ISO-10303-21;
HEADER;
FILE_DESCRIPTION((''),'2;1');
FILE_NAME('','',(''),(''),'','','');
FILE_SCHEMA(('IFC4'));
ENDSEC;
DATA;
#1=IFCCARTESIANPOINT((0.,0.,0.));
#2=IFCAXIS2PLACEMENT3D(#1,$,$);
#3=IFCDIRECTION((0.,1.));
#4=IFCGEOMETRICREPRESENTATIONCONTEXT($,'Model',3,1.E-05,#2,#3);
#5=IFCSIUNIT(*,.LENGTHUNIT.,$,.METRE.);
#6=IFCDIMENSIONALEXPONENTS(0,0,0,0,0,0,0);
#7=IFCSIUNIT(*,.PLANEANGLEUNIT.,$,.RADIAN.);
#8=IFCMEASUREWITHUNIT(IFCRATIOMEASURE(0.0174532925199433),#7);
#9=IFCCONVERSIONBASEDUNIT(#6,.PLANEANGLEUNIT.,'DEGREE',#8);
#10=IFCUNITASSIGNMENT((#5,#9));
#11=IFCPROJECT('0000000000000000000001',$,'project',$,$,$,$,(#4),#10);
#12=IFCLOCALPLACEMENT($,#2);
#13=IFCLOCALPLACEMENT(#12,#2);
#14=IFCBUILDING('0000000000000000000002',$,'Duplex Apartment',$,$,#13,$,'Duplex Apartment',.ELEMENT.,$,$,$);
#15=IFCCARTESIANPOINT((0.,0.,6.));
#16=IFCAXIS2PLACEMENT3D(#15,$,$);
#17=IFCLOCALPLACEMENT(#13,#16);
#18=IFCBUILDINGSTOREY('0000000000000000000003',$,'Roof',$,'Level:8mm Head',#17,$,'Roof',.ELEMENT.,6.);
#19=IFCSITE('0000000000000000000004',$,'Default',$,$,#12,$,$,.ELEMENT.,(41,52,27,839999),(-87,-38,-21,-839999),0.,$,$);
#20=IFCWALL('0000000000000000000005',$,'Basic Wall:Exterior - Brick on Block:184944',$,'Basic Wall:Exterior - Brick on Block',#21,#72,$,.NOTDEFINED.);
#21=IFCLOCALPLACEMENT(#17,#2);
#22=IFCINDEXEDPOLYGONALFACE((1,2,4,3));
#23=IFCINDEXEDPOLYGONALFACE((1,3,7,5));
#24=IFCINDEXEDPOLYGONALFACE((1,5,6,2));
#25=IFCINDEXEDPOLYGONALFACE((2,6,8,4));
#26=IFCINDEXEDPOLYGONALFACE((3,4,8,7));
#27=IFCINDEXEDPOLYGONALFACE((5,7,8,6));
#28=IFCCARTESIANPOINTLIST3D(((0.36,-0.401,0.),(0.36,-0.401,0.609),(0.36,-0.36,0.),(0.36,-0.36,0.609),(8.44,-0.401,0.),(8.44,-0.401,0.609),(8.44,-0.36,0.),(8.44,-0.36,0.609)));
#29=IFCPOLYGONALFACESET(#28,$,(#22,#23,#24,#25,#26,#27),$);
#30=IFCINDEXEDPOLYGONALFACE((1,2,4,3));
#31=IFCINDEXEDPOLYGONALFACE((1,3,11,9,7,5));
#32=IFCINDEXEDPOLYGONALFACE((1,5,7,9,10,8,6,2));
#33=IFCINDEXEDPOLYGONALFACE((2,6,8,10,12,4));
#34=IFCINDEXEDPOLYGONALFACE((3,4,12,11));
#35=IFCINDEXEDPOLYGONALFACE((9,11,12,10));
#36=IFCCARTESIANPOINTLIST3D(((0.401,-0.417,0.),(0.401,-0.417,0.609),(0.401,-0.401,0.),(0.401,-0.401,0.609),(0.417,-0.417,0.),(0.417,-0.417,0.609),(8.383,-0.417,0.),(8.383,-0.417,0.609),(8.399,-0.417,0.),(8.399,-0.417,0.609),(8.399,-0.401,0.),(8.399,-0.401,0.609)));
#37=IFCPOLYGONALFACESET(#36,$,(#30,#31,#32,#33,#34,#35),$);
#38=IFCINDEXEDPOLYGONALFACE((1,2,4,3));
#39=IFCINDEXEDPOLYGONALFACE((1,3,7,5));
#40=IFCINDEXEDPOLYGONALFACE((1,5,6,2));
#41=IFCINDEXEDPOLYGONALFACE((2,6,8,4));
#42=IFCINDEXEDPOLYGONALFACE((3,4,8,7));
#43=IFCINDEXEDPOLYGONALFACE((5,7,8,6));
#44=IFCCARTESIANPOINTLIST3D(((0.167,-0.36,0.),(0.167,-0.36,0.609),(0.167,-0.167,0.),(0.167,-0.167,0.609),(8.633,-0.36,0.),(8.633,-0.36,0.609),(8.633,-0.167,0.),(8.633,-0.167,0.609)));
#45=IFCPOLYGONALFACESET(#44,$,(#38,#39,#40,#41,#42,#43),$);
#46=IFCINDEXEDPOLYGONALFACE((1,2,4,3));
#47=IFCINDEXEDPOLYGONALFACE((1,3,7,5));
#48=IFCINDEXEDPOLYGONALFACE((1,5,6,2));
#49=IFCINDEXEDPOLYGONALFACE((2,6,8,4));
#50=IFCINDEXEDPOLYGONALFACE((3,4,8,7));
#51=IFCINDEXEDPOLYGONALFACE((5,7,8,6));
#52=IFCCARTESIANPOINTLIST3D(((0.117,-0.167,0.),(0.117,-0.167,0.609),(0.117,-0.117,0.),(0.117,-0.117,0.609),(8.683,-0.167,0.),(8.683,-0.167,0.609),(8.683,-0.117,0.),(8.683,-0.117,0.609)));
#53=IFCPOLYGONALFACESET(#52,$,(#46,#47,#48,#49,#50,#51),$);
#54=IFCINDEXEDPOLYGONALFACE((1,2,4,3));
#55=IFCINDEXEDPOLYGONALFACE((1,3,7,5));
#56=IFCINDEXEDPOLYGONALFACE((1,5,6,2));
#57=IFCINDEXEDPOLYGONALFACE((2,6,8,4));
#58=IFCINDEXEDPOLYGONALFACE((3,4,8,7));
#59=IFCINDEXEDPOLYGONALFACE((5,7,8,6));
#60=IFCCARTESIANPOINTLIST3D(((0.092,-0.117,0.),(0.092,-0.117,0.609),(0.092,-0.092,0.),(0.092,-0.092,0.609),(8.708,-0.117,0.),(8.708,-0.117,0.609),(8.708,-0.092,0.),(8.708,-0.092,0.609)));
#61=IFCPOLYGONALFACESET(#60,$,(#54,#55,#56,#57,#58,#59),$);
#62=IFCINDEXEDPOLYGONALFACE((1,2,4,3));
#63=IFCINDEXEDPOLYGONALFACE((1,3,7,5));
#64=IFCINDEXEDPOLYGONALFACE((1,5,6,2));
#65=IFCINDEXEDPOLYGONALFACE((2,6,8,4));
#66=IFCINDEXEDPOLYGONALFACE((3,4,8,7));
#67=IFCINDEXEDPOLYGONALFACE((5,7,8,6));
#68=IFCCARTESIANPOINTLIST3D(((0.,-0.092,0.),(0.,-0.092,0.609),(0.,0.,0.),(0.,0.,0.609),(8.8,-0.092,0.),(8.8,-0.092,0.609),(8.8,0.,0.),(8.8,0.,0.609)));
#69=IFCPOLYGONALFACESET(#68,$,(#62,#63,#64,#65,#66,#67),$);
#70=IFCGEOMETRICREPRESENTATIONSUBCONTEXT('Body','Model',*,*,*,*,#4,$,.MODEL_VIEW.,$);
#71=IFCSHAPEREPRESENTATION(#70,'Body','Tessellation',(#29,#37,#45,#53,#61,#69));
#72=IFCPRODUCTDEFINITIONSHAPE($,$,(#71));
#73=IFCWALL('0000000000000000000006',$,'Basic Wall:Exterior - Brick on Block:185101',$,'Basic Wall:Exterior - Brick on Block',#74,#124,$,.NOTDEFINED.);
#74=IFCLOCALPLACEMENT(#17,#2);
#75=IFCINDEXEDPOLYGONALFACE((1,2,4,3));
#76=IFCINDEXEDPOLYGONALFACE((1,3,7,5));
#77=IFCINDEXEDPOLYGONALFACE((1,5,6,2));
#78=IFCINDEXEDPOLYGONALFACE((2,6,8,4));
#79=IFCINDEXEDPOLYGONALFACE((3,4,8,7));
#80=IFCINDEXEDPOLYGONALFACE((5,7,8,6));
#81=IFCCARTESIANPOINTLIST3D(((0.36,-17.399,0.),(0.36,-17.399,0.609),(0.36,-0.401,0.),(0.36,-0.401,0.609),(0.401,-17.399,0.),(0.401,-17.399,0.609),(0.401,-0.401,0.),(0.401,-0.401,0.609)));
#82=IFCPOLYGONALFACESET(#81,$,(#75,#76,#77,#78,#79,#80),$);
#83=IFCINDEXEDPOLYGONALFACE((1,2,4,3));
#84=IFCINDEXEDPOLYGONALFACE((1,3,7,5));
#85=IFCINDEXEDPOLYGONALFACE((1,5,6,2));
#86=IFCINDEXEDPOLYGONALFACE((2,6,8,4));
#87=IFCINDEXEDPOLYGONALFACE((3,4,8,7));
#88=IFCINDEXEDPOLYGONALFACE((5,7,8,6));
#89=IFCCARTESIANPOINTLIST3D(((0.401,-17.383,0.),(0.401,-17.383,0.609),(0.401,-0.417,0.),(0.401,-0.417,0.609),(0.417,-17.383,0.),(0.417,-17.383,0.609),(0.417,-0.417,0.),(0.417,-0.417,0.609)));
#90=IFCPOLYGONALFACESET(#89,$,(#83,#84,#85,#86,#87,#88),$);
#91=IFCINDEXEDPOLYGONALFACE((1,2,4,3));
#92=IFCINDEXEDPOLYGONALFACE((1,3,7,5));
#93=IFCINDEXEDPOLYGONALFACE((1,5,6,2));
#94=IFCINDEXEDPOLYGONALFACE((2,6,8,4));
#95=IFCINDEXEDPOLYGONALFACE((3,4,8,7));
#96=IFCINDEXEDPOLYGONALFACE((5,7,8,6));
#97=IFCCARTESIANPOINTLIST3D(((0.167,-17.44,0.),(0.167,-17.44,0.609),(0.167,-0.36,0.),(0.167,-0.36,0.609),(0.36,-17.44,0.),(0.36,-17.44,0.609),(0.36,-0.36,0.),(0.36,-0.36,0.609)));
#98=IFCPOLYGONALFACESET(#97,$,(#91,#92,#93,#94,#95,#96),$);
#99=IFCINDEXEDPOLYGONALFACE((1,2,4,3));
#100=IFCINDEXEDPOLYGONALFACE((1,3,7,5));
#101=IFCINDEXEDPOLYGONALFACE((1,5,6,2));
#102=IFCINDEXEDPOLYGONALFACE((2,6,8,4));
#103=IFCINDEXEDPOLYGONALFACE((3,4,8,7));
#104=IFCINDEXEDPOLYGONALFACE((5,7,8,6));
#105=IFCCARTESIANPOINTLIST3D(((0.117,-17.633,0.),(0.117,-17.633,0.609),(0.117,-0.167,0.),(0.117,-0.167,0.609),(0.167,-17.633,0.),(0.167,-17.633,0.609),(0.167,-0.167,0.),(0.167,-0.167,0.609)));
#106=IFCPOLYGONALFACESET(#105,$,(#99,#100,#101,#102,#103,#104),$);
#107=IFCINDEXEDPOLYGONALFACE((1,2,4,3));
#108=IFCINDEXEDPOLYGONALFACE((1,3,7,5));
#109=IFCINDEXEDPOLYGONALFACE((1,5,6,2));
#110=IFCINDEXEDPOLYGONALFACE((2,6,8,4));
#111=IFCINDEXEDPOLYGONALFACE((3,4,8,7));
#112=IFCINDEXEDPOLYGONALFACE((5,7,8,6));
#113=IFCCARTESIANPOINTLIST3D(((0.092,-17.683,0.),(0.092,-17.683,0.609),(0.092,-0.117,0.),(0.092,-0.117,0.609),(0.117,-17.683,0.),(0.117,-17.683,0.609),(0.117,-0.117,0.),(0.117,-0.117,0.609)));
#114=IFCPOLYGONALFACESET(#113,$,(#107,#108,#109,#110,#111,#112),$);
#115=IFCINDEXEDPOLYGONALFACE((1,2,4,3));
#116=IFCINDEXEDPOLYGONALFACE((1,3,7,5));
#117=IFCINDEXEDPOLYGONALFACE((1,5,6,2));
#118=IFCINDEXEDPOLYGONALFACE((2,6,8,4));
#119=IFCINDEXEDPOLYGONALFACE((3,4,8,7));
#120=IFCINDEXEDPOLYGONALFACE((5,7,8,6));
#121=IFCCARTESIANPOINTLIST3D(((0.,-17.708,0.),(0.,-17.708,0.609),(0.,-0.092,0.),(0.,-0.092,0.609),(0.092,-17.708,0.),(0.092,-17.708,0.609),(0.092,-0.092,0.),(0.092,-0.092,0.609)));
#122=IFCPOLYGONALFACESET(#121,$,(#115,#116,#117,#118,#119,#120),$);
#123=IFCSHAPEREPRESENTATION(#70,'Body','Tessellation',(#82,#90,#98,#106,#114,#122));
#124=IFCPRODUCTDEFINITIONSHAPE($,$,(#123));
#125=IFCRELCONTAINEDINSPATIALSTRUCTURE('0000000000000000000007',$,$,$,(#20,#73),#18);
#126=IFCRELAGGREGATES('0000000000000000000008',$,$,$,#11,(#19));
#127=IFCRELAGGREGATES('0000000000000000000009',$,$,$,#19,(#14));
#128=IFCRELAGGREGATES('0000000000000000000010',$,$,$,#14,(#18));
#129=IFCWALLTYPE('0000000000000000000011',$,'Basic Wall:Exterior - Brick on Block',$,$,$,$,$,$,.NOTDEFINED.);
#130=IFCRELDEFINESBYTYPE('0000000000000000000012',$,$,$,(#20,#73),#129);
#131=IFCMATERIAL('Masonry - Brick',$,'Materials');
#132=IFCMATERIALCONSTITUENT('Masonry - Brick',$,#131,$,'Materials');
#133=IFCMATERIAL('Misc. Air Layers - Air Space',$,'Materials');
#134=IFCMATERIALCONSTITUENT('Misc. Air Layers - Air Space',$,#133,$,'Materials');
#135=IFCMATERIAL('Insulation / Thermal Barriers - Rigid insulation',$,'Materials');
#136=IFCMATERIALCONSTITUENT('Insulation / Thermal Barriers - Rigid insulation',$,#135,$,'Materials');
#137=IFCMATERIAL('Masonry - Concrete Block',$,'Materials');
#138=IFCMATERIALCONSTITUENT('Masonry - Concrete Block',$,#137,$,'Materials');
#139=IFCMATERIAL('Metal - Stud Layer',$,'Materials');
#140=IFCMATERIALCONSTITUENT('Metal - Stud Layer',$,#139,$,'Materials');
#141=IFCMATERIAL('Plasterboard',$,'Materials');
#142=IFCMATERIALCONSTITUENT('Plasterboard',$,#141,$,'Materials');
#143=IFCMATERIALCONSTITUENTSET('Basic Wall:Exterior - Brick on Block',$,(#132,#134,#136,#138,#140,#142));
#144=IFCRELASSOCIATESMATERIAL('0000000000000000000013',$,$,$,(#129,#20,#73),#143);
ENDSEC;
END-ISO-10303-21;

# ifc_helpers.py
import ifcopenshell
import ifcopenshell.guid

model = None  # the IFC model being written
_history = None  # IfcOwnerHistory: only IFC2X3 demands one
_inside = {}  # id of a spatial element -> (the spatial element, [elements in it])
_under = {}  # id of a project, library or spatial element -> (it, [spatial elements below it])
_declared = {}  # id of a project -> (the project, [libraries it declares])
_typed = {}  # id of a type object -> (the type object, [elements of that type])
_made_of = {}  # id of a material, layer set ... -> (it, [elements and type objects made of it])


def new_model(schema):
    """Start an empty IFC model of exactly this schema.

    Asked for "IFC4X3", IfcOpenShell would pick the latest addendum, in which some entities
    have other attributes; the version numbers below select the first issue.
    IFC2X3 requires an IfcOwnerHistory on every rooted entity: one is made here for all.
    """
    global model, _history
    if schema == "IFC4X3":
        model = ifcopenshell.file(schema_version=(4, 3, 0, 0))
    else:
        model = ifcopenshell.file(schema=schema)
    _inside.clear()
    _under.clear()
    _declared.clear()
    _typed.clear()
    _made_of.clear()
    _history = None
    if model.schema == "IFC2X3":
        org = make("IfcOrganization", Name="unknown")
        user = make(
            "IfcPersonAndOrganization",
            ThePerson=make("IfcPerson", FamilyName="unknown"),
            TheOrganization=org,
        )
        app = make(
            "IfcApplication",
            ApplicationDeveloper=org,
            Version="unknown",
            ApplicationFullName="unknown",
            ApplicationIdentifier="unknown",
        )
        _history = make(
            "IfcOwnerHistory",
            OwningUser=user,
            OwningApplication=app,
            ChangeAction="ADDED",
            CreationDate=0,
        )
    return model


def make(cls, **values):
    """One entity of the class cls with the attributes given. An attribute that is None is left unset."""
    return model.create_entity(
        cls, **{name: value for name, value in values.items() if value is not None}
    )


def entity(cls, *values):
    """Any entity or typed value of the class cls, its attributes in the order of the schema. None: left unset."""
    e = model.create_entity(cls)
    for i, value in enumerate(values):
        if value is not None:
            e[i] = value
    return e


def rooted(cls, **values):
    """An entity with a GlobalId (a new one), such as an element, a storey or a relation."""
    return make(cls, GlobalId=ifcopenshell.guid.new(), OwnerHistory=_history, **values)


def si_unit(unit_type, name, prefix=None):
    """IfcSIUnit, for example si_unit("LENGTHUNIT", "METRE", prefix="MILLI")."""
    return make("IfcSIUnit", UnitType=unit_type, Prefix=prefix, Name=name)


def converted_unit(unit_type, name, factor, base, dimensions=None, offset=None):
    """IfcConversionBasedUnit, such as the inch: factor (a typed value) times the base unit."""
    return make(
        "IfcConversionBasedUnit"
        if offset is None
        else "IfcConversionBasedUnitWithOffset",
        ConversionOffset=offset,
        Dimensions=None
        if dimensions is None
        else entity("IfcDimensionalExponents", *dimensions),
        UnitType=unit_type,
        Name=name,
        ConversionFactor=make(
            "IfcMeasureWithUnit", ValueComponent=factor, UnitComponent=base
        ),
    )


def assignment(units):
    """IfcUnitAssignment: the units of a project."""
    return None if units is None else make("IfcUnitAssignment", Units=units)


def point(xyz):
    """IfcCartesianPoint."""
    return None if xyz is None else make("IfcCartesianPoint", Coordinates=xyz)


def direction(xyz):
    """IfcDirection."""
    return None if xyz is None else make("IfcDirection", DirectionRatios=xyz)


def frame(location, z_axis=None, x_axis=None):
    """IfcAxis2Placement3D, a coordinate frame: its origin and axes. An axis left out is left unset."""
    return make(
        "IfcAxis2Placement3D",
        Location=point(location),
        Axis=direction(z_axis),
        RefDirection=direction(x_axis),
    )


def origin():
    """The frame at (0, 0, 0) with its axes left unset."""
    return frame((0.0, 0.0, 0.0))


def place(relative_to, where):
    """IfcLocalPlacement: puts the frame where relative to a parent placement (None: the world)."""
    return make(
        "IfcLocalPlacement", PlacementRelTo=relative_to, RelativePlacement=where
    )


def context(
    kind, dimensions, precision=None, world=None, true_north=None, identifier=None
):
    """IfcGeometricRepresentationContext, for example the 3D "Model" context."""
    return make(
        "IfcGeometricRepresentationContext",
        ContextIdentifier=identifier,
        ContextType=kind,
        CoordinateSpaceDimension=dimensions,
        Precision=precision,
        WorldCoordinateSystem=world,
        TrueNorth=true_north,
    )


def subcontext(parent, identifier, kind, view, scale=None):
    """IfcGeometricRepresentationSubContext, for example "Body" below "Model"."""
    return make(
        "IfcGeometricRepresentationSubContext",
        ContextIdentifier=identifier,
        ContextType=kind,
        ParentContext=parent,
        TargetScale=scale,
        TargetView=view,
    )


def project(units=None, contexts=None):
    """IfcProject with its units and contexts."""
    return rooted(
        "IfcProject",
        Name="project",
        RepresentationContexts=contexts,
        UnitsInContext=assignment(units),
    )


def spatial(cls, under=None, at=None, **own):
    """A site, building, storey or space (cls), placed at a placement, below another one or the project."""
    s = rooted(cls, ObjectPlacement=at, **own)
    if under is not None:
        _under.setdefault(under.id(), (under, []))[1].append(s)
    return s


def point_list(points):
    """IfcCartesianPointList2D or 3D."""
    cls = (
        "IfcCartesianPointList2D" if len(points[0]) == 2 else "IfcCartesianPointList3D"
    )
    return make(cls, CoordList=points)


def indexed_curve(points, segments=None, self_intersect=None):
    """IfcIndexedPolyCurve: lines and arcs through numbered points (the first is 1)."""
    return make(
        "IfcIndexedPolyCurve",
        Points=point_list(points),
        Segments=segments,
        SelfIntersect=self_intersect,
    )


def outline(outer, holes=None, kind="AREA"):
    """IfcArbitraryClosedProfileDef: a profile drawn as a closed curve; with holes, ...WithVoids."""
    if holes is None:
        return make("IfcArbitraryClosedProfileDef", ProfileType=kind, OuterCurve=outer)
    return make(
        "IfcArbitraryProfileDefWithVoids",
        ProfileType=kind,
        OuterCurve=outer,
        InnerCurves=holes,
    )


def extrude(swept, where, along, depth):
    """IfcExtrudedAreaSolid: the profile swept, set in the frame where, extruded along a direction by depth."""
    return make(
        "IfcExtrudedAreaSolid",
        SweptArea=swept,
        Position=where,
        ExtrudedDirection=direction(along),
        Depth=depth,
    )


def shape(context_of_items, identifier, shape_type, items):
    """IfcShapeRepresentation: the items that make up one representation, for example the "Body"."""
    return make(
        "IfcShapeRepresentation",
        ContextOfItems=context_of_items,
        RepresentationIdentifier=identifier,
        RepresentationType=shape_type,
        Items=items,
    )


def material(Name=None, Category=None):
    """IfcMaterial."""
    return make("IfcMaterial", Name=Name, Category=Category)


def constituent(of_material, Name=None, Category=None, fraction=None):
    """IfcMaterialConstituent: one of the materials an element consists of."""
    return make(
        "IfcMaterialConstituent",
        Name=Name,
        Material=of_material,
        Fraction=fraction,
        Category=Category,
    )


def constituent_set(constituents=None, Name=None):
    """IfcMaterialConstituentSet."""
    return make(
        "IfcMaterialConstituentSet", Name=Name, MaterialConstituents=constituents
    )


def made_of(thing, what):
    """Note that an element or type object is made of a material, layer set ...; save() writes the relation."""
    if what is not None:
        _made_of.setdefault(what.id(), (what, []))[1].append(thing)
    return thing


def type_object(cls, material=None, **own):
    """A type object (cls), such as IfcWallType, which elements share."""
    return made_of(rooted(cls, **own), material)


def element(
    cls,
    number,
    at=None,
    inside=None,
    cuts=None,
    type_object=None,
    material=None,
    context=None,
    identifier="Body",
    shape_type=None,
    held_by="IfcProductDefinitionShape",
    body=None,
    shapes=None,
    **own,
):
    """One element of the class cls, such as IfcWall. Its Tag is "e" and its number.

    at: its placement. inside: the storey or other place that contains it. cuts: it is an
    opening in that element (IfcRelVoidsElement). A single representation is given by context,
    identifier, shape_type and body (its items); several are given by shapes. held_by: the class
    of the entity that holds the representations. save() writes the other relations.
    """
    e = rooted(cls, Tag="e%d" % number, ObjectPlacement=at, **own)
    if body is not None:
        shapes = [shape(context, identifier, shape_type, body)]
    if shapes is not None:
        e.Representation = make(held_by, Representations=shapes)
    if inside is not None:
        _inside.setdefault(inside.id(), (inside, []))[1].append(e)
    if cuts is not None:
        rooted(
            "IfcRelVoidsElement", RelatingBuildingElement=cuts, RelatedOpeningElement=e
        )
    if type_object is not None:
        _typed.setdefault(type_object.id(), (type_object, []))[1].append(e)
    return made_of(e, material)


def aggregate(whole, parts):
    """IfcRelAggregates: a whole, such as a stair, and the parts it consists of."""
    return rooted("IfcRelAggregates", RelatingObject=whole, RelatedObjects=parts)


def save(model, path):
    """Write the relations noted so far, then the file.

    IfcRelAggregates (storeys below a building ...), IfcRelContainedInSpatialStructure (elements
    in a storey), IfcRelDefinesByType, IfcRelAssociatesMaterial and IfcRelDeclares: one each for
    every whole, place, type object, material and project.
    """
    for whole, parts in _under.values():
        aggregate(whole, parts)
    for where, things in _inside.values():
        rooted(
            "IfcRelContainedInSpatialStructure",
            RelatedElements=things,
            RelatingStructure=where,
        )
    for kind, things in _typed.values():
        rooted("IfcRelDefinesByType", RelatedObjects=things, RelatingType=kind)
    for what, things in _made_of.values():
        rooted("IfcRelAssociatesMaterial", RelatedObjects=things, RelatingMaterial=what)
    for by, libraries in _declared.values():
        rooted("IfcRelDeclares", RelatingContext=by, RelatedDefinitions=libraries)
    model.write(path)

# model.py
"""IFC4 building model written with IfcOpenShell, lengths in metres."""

from ifc_helpers import new_model, entity, si_unit, converted_unit, direction, frame, origin, place, context, subcontext, project, spatial, indexed_curve, outline, extrude, material, constituent, constituent_set, type_object, element, save


model = new_model("IFC4")

# Units and contexts
model_context = context("Model", 3, precision=1e-05, world=origin(), true_north=direction((0.0, 1.0)))
body_context = subcontext(model_context, "Body", "Model", "MODEL_VIEW")
ifc_project = project(units=[si_unit("LENGTHUNIT", "METRE"), converted_unit("PLANEANGLEUNIT", "DEGREE", entity("IfcRatioMeasure", 0.0174532925199433), si_unit("PLANEANGLEUNIT", "RADIAN"), dimensions=[0, 0, 0, 0, 0, 0, 0])], contexts=[model_context])

# Site, building, storey
site_placement = place(None, origin())
site = spatial("IfcSite", under=ifc_project, at=site_placement, Name="Default", CompositionType="ELEMENT", RefLatitude=(41, 52, 27, 839999), RefLongitude=(-87, -38, -21, -839999), RefElevation=0.0)
building_placement = place(site_placement, origin())
building = spatial("IfcBuilding", under=site, at=building_placement, Name="Duplex Apartment", LongName="Duplex Apartment", CompositionType="ELEMENT")
storey_placement = place(building_placement, frame((0.0, 0.0, 6.0)))
storey = spatial("IfcBuildingStorey", under=building, at=storey_placement, Name="Roof", ObjectType="Level:8mm Head", LongName="Roof", CompositionType="ELEMENT", Elevation=6.0)

# Shared definitions
ifc_material_1 = material(Name="Insulation / Thermal Barriers - Rigid insulation", Category="Materials")

# Walls
ifc_material_2 = material(Name="Masonry - Brick", Category="Materials")
ifc_constituent_1 = constituent(ifc_material_2, Name="Masonry - Brick", Category="Materials")
ifc_material_3 = material(Name="Misc. Air Layers - Air Space", Category="Materials")
ifc_constituent_2 = constituent(ifc_material_3, Name="Misc. Air Layers - Air Space", Category="Materials")
ifc_constituent_3 = constituent(ifc_material_1, Name="Insulation / Thermal Barriers - Rigid insulation", Category="Materials")
ifc_material_4 = material(Name="Masonry - Concrete Block", Category="Materials")
ifc_constituent_4 = constituent(ifc_material_4, Name="Masonry - Concrete Block", Category="Materials")
ifc_material_5 = material(Name="Metal - Stud Layer", Category="Materials")
ifc_constituent_5 = constituent(ifc_material_5, Name="Metal - Stud Layer", Category="Materials")
ifc_material_6 = material(Name="Plasterboard", Category="Materials")
ifc_constituent_6 = constituent(ifc_material_6, Name="Plasterboard", Category="Materials")
ifc_constituent_set_1 = constituent_set(constituents=[ifc_constituent_1, ifc_constituent_2, ifc_constituent_3, ifc_constituent_4, ifc_constituent_5, ifc_constituent_6], Name="Basic Wall:Exterior - Brick on Block")
wall_type = type_object("IfcWallType", Name="Basic Wall:Exterior - Brick on Block", PredefinedType="NOTDEFINED", material=ifc_constituent_set_1)
wall_1_placement = place(storey_placement, frame((0.0, -0.2085, 0.0)))
element("IfcWall", 1, at=wall_1_placement, inside=storey, type_object=wall_type, material=ifc_constituent_set_1, Name="Basic Wall:Exterior - Brick on Block:184944", ObjectType="Basic Wall:Exterior - Brick on Block", PredefinedType="NOTDEFINED", context=body_context, shape_type="SweptSolid", body=[
    extrude(outline(indexed_curve([(-4.04, -0.0205), (4.04, -0.0205), (4.04, 0.0205), (-4.04, 0.0205), (-4.04, -0.0205)], self_intersect=False)), frame((4.4, -0.172, 0.0)), (0.0, 0.0, 1.0), 0.609),
    extrude(outline(indexed_curve([(-3.983, -0.0053), (3.983, -0.0053), (3.999, -0.0053), (3.999, 0.0107), (-3.999, 0.0107), (-3.999, -0.0053), (-3.983, -0.0053)], self_intersect=False)), frame((4.4, -0.2032, 0.0)), (0.0, 0.0, 1.0), 0.609),
    extrude(outline(indexed_curve([(-4.233, -0.0965), (4.233, -0.0965), (4.233, 0.0965), (-4.233, 0.0965), (-4.233, -0.0965)], self_intersect=False)), frame((4.4, -0.055, 0.0)), (0.0, 0.0, 1.0), 0.609),
    extrude(outline(indexed_curve([(-4.283, -0.025), (4.283, -0.025), (4.283, 0.025), (-4.283, 0.025), (-4.283, -0.025)], self_intersect=False)), frame((4.4, 0.0665, 0.0)), (0.0, 0.0, 1.0), 0.609),
    extrude(outline(indexed_curve([(-4.308, -0.0125), (4.308, -0.0125), (4.308, 0.0125), (-4.308, 0.0125), (-4.308, -0.0125)], self_intersect=False)), frame((4.4, 0.104, 0.0)), (0.0, 0.0, 1.0), 0.609),
    extrude(outline(indexed_curve([(-0.046, -4.4), (0.046, -4.4), (0.046, 4.4), (-0.046, 4.4), (-0.046, -4.4)], self_intersect=False)), frame((4.4, 0.1625, 0.0), z_axis=(0.0, 0.0, 1.0), x_axis=(0.0, -1.0, 0.0)), (0.0, 0.0, 1.0), 0.609),
])
wall_2_placement = place(storey_placement, frame((0.2085, -17.383, 0.0), z_axis=(0.0, 0.0, 1.0), x_axis=(0.0, 1.0, 0.0)))
element("IfcWall", 2, at=wall_2_placement, inside=storey, type_object=wall_type, material=ifc_constituent_set_1, Name="Basic Wall:Exterior - Brick on Block:185101", ObjectType="Basic Wall:Exterior - Brick on Block", PredefinedType="NOTDEFINED", context=body_context, shape_type="SweptSolid", body=[
    extrude(outline(indexed_curve([(-8.499, -0.0205), (8.499, -0.0205), (8.499, 0.0205), (-8.499, 0.0205), (-8.499, -0.0205)], self_intersect=False)), frame((8.483, -0.172, 0.0)), (0.0, 0.0, 1.0), 0.609),
    extrude(outline(indexed_curve([(-0.008, -8.483), (0.008, -8.483), (0.008, 8.483), (-0.008, 8.483), (-0.008, -8.483)], self_intersect=False)), frame((8.483, -0.2005, 0.0), z_axis=(0.0, 0.0, 1.0), x_axis=(0.0, 1.0, 0.0)), (0.0, 0.0, 1.0), 0.609),
    extrude(outline(indexed_curve([(-8.54, -0.0965), (8.54, -0.0965), (8.54, 0.0965), (-8.54, 0.0965), (-8.54, -0.0965)], self_intersect=False)), frame((8.483, -0.055, 0.0)), (0.0, 0.0, 1.0), 0.609),
    extrude(outline(indexed_curve([(-8.733, -0.025), (8.733, -0.025), (8.733, 0.025), (-8.733, 0.025), (-8.733, -0.025)], self_intersect=False)), frame((8.483, 0.0665, 0.0)), (0.0, 0.0, 1.0), 0.609),
    extrude(outline(indexed_curve([(-8.783, -0.0125), (8.783, -0.0125), (8.783, 0.0125), (-8.783, 0.0125), (-8.783, -0.0125)], self_intersect=False)), frame((8.483, 0.104, 0.0)), (0.0, 0.0, 1.0), 0.609),
    extrude(outline(indexed_curve([(-0.046, -8.808), (0.046, -8.808), (0.046, 8.808), (-0.046, 8.808), (-0.046, -8.808)], self_intersect=False)), frame((8.483, 0.1625, 0.0), z_axis=(0.0, 0.0, 1.0), x_axis=(0.0, -1.0, 0.0)), (0.0, 0.0, 1.0), 0.609),
])

save(model, "model.ifc")
